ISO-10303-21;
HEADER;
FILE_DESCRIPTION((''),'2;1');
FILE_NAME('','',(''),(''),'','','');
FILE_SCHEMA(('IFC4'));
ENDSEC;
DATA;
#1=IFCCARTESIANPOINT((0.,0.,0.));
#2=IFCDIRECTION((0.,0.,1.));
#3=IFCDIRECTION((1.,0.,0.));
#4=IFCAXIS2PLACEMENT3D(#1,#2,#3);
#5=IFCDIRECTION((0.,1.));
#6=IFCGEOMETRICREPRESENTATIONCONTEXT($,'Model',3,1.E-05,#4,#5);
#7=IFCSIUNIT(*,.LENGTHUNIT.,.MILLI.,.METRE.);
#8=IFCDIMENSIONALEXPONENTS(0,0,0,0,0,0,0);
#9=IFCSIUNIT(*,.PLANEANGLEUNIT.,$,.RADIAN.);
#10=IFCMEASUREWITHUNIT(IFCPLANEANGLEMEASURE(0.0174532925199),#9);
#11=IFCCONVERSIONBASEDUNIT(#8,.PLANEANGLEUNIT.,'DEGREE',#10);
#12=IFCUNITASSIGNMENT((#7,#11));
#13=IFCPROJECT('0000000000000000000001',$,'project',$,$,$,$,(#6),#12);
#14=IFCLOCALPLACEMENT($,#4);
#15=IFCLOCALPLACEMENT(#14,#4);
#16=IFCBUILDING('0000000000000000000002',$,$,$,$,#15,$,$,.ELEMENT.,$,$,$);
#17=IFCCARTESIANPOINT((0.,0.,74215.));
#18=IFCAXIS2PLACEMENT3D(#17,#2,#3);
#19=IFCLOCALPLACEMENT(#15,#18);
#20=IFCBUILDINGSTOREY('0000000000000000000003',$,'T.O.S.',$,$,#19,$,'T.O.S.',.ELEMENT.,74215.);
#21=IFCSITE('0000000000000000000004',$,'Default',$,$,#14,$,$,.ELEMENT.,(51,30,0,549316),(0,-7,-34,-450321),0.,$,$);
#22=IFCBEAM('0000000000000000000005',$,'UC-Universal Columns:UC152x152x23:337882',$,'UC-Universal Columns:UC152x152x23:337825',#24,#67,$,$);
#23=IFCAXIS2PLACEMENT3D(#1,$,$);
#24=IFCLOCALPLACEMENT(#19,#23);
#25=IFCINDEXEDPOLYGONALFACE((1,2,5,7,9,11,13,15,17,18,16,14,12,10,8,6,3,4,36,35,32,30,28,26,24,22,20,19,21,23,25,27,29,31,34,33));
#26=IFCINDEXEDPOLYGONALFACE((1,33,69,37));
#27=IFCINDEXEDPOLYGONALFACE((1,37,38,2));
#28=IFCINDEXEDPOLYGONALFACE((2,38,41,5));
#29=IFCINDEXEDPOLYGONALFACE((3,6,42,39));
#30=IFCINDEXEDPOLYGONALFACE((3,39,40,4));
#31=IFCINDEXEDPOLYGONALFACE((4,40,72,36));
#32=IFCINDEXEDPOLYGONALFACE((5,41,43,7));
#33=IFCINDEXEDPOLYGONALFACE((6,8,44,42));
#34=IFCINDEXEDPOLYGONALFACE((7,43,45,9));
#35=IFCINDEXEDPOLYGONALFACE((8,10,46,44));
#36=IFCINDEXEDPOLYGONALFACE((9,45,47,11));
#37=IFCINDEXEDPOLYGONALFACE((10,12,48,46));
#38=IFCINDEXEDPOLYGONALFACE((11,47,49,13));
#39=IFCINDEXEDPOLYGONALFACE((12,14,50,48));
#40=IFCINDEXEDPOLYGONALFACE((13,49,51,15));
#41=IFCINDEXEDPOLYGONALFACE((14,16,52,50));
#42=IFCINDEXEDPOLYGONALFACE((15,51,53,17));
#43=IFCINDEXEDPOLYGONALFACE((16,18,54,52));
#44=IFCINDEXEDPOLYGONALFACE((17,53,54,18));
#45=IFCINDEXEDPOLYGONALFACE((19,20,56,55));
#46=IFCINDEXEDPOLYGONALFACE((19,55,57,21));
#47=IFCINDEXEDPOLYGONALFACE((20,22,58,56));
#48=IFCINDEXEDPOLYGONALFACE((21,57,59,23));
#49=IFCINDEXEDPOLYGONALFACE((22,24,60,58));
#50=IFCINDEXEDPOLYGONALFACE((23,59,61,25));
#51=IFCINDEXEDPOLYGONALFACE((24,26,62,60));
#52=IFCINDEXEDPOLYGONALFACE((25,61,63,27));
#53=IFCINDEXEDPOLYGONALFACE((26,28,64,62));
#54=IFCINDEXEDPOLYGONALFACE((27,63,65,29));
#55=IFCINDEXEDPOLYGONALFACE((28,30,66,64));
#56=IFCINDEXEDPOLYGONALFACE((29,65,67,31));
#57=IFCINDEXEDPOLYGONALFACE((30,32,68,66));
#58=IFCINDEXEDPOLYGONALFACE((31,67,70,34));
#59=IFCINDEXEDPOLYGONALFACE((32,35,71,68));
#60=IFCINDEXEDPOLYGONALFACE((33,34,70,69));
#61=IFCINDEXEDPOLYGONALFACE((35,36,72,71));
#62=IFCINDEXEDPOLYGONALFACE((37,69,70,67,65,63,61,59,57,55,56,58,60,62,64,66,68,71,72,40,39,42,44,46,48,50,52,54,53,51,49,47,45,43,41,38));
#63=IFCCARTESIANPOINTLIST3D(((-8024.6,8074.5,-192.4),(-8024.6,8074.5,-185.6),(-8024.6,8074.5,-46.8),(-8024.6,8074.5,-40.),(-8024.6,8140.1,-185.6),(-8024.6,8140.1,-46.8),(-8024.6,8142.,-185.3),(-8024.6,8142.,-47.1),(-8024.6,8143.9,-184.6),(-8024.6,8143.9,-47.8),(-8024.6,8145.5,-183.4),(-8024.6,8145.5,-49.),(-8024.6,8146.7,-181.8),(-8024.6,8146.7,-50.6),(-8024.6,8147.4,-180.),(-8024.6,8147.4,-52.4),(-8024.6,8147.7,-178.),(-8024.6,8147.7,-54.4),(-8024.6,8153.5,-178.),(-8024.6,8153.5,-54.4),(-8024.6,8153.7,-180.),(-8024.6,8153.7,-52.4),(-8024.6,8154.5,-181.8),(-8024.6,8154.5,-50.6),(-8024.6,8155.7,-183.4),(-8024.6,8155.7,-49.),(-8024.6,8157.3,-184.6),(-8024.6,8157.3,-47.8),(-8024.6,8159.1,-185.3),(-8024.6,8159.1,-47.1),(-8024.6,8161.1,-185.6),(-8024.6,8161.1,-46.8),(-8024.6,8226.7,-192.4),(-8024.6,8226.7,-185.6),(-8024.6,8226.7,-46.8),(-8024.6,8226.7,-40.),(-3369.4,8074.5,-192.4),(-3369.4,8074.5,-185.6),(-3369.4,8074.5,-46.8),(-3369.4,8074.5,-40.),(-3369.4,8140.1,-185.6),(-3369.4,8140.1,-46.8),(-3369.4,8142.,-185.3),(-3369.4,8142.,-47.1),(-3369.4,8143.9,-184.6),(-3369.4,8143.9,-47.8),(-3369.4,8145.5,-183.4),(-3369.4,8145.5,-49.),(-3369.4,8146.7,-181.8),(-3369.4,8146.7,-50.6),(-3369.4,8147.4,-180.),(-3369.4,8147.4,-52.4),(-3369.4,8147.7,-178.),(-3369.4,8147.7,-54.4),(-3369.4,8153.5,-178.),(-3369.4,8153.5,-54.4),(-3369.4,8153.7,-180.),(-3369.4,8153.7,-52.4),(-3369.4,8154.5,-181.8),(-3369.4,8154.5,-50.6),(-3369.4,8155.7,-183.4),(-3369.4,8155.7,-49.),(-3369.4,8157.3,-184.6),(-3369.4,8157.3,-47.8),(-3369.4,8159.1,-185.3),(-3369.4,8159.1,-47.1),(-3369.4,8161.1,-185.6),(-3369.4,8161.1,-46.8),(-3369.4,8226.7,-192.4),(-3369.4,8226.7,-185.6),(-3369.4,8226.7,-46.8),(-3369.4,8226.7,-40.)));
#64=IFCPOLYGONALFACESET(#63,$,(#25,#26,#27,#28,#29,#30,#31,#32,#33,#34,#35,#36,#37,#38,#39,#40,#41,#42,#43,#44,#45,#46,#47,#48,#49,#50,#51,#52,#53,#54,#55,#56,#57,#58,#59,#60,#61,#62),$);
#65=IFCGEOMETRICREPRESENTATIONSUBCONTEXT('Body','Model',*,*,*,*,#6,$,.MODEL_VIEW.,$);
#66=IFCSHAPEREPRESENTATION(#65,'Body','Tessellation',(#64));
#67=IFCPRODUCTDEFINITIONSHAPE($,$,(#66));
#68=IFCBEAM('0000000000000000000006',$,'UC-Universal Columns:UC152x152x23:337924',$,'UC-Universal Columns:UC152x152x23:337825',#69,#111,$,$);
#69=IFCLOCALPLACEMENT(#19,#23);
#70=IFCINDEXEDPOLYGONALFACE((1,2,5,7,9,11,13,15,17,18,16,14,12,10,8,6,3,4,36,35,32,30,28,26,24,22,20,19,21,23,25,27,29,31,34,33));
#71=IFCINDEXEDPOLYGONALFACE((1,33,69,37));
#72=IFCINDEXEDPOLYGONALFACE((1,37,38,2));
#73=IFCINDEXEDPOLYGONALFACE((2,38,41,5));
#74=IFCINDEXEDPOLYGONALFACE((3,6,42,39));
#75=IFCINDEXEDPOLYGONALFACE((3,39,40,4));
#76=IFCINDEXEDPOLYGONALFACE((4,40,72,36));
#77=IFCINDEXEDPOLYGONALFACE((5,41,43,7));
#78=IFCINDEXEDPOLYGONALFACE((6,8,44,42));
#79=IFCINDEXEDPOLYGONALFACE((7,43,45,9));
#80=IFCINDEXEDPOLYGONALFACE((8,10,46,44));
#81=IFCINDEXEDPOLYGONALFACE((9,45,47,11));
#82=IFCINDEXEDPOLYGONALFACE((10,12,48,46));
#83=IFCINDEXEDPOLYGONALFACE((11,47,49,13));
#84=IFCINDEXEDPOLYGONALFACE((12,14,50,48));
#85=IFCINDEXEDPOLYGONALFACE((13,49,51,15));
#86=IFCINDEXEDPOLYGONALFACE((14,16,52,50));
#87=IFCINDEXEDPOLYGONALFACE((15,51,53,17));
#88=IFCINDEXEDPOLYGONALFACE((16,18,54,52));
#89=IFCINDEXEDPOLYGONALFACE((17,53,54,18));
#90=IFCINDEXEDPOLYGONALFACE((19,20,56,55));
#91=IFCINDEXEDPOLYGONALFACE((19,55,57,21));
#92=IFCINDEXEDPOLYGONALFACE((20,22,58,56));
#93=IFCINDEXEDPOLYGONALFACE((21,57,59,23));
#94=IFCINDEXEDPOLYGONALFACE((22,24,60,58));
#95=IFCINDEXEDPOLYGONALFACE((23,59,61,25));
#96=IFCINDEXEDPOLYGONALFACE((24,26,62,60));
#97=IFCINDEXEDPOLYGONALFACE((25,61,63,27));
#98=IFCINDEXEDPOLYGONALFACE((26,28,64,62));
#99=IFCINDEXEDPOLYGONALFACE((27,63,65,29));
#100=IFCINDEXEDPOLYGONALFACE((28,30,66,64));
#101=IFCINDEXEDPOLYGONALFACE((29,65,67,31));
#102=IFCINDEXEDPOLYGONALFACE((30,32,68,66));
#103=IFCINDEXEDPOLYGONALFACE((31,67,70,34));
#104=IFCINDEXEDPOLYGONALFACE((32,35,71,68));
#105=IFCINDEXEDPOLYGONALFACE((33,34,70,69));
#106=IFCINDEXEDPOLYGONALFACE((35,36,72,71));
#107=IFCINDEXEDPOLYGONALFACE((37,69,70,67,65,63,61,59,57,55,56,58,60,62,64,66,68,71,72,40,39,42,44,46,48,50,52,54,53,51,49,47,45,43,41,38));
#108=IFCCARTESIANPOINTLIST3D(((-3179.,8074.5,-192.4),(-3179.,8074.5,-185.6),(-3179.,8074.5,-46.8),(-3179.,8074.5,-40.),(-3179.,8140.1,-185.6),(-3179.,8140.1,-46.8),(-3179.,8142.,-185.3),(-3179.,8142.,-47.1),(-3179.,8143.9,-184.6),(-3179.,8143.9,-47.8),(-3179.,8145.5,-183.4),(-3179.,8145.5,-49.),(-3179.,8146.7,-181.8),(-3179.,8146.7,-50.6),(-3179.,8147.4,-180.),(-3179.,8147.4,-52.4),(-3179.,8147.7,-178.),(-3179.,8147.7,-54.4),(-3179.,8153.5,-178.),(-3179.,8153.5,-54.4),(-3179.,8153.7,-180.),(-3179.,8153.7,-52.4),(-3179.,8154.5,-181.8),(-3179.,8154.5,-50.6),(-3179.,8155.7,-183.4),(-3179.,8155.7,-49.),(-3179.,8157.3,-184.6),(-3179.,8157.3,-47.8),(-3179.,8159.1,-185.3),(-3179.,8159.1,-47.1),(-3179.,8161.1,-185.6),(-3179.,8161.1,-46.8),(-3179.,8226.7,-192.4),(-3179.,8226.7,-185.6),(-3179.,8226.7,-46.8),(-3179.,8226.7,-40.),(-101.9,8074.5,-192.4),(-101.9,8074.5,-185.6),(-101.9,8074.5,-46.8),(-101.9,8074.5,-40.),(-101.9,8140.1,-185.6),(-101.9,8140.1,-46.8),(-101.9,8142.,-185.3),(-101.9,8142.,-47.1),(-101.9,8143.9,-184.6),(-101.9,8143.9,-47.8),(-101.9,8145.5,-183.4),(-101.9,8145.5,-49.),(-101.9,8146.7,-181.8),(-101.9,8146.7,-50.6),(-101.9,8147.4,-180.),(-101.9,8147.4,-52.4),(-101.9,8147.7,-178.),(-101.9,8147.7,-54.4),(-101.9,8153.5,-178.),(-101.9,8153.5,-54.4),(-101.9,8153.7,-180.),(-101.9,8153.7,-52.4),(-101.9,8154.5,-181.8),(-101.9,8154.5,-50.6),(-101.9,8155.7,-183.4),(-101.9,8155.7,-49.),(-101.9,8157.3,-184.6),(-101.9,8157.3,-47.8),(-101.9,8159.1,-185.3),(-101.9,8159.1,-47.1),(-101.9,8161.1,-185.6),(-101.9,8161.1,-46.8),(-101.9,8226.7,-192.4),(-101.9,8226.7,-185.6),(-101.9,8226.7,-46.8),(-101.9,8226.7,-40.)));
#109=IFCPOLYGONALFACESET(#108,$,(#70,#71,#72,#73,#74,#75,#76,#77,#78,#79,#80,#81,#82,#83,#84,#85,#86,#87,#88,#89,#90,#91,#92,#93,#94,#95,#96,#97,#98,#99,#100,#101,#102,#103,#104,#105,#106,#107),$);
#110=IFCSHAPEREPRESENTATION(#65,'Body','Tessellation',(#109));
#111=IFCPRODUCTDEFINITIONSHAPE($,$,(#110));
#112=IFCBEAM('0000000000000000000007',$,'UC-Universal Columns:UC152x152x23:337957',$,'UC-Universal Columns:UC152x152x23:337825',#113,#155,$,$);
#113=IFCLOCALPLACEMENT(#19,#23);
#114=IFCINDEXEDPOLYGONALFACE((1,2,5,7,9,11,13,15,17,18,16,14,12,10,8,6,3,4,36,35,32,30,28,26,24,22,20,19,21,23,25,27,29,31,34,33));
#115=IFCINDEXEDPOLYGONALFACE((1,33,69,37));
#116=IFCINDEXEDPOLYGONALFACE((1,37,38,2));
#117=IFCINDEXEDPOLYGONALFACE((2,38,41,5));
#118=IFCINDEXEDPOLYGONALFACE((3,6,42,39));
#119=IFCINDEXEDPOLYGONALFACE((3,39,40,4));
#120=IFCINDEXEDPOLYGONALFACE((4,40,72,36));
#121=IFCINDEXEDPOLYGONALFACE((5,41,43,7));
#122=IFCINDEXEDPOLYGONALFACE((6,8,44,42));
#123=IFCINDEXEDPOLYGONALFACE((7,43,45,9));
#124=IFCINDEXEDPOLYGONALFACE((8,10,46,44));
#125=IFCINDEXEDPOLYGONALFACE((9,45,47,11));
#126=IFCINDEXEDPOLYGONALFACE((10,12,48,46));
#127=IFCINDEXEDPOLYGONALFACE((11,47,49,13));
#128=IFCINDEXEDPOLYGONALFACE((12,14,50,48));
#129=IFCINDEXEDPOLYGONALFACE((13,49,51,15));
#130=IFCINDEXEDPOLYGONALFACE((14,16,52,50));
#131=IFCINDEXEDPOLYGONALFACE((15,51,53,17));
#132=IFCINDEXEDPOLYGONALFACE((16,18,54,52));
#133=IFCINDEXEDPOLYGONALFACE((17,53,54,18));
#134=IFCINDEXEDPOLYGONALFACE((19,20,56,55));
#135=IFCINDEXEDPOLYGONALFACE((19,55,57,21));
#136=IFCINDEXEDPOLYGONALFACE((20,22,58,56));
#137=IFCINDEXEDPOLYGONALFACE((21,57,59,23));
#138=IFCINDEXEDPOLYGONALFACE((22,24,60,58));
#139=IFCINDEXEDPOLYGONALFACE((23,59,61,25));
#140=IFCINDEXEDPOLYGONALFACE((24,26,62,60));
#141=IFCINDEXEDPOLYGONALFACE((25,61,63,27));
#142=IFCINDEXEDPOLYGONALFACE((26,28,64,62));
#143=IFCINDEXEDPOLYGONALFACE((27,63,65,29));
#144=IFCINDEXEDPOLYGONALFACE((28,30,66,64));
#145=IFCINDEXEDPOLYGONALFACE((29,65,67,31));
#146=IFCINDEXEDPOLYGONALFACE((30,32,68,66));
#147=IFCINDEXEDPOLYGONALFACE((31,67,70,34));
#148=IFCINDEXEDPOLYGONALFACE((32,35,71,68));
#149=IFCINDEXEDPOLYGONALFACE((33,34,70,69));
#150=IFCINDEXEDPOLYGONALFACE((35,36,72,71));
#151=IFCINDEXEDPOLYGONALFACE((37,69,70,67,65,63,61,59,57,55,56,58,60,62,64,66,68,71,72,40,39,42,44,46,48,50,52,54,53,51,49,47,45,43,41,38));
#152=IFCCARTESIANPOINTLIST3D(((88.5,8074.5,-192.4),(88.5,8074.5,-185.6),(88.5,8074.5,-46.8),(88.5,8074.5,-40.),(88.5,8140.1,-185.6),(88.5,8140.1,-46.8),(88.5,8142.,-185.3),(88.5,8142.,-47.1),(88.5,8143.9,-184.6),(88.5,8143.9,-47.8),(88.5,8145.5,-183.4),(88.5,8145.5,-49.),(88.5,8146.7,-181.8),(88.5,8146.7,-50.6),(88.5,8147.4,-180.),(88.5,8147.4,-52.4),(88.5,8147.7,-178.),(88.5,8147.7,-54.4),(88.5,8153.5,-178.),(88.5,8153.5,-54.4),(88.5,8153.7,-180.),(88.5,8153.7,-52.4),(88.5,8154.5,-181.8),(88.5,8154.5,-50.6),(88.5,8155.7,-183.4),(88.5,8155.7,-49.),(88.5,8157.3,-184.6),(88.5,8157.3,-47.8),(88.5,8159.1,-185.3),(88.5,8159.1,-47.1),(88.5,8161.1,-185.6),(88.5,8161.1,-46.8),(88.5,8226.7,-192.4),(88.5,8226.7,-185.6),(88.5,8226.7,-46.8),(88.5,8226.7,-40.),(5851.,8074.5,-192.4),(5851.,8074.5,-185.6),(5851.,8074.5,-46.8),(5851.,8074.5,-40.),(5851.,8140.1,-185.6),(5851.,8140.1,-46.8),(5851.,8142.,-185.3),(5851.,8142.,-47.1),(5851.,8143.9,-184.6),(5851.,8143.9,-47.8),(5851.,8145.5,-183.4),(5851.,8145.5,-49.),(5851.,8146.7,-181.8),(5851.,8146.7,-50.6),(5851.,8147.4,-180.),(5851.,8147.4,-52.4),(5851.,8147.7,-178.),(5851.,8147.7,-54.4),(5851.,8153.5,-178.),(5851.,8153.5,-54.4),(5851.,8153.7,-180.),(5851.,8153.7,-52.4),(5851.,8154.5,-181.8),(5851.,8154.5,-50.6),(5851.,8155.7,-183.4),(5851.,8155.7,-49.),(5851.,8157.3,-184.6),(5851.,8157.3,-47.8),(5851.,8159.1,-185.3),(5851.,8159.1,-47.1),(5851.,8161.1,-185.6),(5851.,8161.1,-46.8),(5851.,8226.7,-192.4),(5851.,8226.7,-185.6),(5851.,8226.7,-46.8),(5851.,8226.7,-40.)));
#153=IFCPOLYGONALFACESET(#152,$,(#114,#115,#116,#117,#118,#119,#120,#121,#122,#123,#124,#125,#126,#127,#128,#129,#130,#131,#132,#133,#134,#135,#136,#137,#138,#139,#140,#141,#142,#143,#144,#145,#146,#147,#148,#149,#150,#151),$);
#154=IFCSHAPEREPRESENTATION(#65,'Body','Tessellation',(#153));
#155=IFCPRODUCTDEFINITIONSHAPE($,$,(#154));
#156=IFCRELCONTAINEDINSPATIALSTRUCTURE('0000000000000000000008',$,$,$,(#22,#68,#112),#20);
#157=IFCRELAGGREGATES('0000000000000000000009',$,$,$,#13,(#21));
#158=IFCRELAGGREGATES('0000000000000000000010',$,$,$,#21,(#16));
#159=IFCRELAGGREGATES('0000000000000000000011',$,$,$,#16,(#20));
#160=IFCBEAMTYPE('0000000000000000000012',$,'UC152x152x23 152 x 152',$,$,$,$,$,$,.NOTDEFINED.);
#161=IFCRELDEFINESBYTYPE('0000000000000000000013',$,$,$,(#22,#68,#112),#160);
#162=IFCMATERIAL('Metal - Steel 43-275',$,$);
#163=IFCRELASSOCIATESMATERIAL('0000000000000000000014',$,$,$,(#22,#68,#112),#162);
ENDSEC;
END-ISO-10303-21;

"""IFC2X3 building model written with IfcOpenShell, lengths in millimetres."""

from ifc_helpers import new_model, entity, si_unit, converted_unit, point, direction, frame, frame_2d, origin_with_axes, place, context, subcontext, project, spatial, polyline, circle_curve, parameter, trimmed, segment, composite_curve, outline, extrude, material, type_object, element, save


model = new_model("IFC2X3")

# Units and contexts
model_context = context("Model", 3, precision=1e-05, world=origin_with_axes(), true_north=direction((0.0, 1.0)))
body_context = subcontext(model_context, "Body", "Model", "MODEL_VIEW")
ifc_project = project(units=[si_unit("LENGTHUNIT", "METRE", prefix="MILLI"), converted_unit("PLANEANGLEUNIT", "DEGREE", entity("IfcPlaneAngleMeasure", 0.0174532925199), si_unit("PLANEANGLEUNIT", "RADIAN"), dimensions=[0, 0, 0, 0, 0, 0, 0])], contexts=[model_context])

# Site, building, storey
site_placement = place(None, origin_with_axes())
site = spatial("IfcSite", under=ifc_project, at=site_placement, Name="Default", CompositionType="ELEMENT", RefLatitude=(51, 30, 0, 549316), RefLongitude=(0, -7, -34, -450321), RefElevation=0.0)
building_placement = place(site_placement, origin_with_axes())
building = spatial("IfcBuilding", under=site, at=building_placement, CompositionType="ELEMENT")
storey_placement = place(building_placement, frame((0.0, 0.0, 74215.0), z_axis=(0.0, 0.0, 1.0), x_axis=(1.0, 0.0, 0.0)))
storey = spatial("IfcBuildingStorey", under=building, at=storey_placement, Name="T.O.S.", LongName="T.O.S.", CompositionType="ELEMENT", Elevation=74215.0)

# Beams
ifc_material = material(Name="Metal - Steel 43-275")
beam_type_1 = type_object("IfcBeamType", Name="UC152x152x23 152 x 152", PredefinedType="NOTDEFINED")
beam_1_placement = place(storey_placement, frame((-3369.4, 8150.6, -116.2), z_axis=(0.0, 0.0, 1.0), x_axis=(0.0, 1.0, 0.0)))
element("IfcBeam", 1, at=beam_1_placement, inside=storey, type_object=beam_type_1, material=ifc_material, Name="UC-Universal Columns:UC152x152x23:337882", ObjectType="UC-Universal Columns:UC152x152x23:337825", context=body_context, shape_type="SweptSolid", body=[
    extrude(outline(composite_curve([segment(polyline([(76.2, 76.1), (69.4, 76.1), (69.4, 10.5)]), True, "CONTINUOUS"), segment(trimmed(circle_curve(frame_2d((61.8, 10.5), x_axis=(0.0, -1.0)), 7.6), [point((69.4, 10.5)), parameter(90.0)], [point((61.8, 2.9)), parameter(0.0)], False, "CARTESIAN"), True, "CONTINUOUS"), segment(polyline([(61.8, 2.9), (-61.8, 2.9)]), True, "CONTINUOUS"), segment(trimmed(circle_curve(frame_2d((-61.8, 10.5), x_axis=(-1.0, 0.0)), 7.6), [point((-61.8, 2.9)), parameter(90.0)], [point((-69.4, 10.5)), parameter(0.0)], False, "CARTESIAN"), True, "CONTINUOUS"), segment(polyline([(-69.4, 10.5), (-69.4, 76.1), (-76.2, 76.1), (-76.2, -76.1), (-69.4, -76.1), (-69.4, -10.5)]), True, "CONTINUOUS"), segment(trimmed(circle_curve(frame_2d((-61.8, -10.5), x_axis=(0.0, 1.0)), 7.6), [point((-69.4, -10.5)), parameter(90.0)], [point((-61.8, -2.9)), parameter(0.0)], False, "CARTESIAN"), True, "CONTINUOUS"), segment(polyline([(-61.8, -2.9), (61.8, -2.9)]), True, "CONTINUOUS"), segment(trimmed(circle_curve(frame_2d((61.8, -10.5), x_axis=(1.0, 0.0)), 7.6), [point((61.8, -2.9)), parameter(90.0)], [point((69.4, -10.5)), parameter(0.0)], False, "CARTESIAN"), True, "CONTINUOUS"), segment(polyline([(69.4, -10.5), (69.4, -76.1), (76.2, -76.1), (76.2, 76.1)]), True, "CONTINUOUS")], self_intersect=False)), frame((0.0, 4655.2, 0.0), z_axis=(0.0, -1.0, 0.0), x_axis=(0.0, 0.0, -1.0)), (0.0, 0.0, 1.0), 4655.2),
])
beam_2_placement = place(storey_placement, frame((-101.9, 8150.6, -116.2), z_axis=(0.0, 0.0, 1.0), x_axis=(0.0, 1.0, 0.0)))
element("IfcBeam", 2, at=beam_2_placement, inside=storey, type_object=beam_type_1, material=ifc_material, Name="UC-Universal Columns:UC152x152x23:337924", ObjectType="UC-Universal Columns:UC152x152x23:337825", context=body_context, shape_type="SweptSolid", body=[
    extrude(outline(composite_curve([segment(polyline([(76.2, 76.1), (69.4, 76.1), (69.4, 10.5)]), True, "CONTINUOUS"), segment(trimmed(circle_curve(frame_2d((61.8, 10.5), x_axis=(0.0, -1.0)), 7.6), [point((69.4, 10.5)), parameter(90.0)], [point((61.8, 2.9)), parameter(0.0)], False, "CARTESIAN"), True, "CONTINUOUS"), segment(polyline([(61.8, 2.9), (-61.8, 2.9)]), True, "CONTINUOUS"), segment(trimmed(circle_curve(frame_2d((-61.8, 10.5), x_axis=(-1.0, 0.0)), 7.6), [point((-61.8, 2.9)), parameter(90.0)], [point((-69.4, 10.5)), parameter(0.0)], False, "CARTESIAN"), True, "CONTINUOUS"), segment(polyline([(-69.4, 10.5), (-69.4, 76.1), (-76.2, 76.1), (-76.2, -76.1), (-69.4, -76.1), (-69.4, -10.5)]), True, "CONTINUOUS"), segment(trimmed(circle_curve(frame_2d((-61.8, -10.5), x_axis=(0.0, 1.0)), 7.6), [point((-69.4, -10.5)), parameter(90.0)], [point((-61.8, -2.9)), parameter(0.0)], False, "CARTESIAN"), True, "CONTINUOUS"), segment(polyline([(-61.8, -2.9), (61.8, -2.9)]), True, "CONTINUOUS"), segment(trimmed(circle_curve(frame_2d((61.8, -10.5), x_axis=(1.0, 0.0)), 7.6), [point((61.8, -2.9)), parameter(90.0)], [point((69.4, -10.5)), parameter(0.0)], False, "CARTESIAN"), True, "CONTINUOUS"), segment(polyline([(69.4, -10.5), (69.4, -76.1), (76.2, -76.1), (76.2, 76.1)]), True, "CONTINUOUS")], self_intersect=False)), frame((0.0, 3077.1, 0.0), z_axis=(0.0, -1.0, 0.0), x_axis=(0.0, 0.0, -1.0)), (0.0, 0.0, 1.0), 3077.1),
])
beam_3_placement = place(storey_placement, frame((5851.0, 8150.6, -116.2), z_axis=(0.0, 0.0, 1.0), x_axis=(0.0, 1.0, 0.0)))
element("IfcBeam", 3, at=beam_3_placement, inside=storey, type_object=beam_type_1, material=ifc_material, Name="UC-Universal Columns:UC152x152x23:337957", ObjectType="UC-Universal Columns:UC152x152x23:337825", context=body_context, shape_type="SweptSolid", body=[
    extrude(outline(composite_curve([segment(polyline([(76.2, 76.1), (69.4, 76.1), (69.4, 10.5)]), True, "CONTINUOUS"), segment(trimmed(circle_curve(frame_2d((61.8, 10.5), x_axis=(0.0, -1.0)), 7.6), [point((69.4, 10.5)), parameter(90.0)], [point((61.8, 2.9)), parameter(0.0)], False, "CARTESIAN"), True, "CONTINUOUS"), segment(polyline([(61.8, 2.9), (-61.8, 2.9)]), True, "CONTINUOUS"), segment(trimmed(circle_curve(frame_2d((-61.8, 10.5), x_axis=(-1.0, 0.0)), 7.6), [point((-61.8, 2.9)), parameter(90.0)], [point((-69.4, 10.5)), parameter(0.0)], False, "CARTESIAN"), True, "CONTINUOUS"), segment(polyline([(-69.4, 10.5), (-69.4, 76.1), (-76.2, 76.1), (-76.2, -76.1), (-69.4, -76.1), (-69.4, -10.5)]), True, "CONTINUOUS"), segment(trimmed(circle_curve(frame_2d((-61.8, -10.5), x_axis=(0.0, 1.0)), 7.6), [point((-69.4, -10.5)), parameter(90.0)], [point((-61.8, -2.9)), parameter(0.0)], False, "CARTESIAN"), True, "CONTINUOUS"), segment(polyline([(-61.8, -2.9), (61.8, -2.9)]), True, "CONTINUOUS"), segment(trimmed(circle_curve(frame_2d((61.8, -10.5), x_axis=(1.0, 0.0)), 7.6), [point((61.8, -2.9)), parameter(90.0)], [point((69.4, -10.5)), parameter(0.0)], False, "CARTESIAN"), True, "CONTINUOUS"), segment(polyline([(69.4, -10.5), (69.4, -76.1), (76.2, -76.1), (76.2, 76.1)]), True, "CONTINUOUS")], self_intersect=False)), frame((0.0, 5762.5, 0.0), z_axis=(0.0, -1.0, 0.0), x_axis=(0.0, 0.0, -1.0)), (0.0, 0.0, 1.0), 5762.5),
])

save(model, "model.ifc")
